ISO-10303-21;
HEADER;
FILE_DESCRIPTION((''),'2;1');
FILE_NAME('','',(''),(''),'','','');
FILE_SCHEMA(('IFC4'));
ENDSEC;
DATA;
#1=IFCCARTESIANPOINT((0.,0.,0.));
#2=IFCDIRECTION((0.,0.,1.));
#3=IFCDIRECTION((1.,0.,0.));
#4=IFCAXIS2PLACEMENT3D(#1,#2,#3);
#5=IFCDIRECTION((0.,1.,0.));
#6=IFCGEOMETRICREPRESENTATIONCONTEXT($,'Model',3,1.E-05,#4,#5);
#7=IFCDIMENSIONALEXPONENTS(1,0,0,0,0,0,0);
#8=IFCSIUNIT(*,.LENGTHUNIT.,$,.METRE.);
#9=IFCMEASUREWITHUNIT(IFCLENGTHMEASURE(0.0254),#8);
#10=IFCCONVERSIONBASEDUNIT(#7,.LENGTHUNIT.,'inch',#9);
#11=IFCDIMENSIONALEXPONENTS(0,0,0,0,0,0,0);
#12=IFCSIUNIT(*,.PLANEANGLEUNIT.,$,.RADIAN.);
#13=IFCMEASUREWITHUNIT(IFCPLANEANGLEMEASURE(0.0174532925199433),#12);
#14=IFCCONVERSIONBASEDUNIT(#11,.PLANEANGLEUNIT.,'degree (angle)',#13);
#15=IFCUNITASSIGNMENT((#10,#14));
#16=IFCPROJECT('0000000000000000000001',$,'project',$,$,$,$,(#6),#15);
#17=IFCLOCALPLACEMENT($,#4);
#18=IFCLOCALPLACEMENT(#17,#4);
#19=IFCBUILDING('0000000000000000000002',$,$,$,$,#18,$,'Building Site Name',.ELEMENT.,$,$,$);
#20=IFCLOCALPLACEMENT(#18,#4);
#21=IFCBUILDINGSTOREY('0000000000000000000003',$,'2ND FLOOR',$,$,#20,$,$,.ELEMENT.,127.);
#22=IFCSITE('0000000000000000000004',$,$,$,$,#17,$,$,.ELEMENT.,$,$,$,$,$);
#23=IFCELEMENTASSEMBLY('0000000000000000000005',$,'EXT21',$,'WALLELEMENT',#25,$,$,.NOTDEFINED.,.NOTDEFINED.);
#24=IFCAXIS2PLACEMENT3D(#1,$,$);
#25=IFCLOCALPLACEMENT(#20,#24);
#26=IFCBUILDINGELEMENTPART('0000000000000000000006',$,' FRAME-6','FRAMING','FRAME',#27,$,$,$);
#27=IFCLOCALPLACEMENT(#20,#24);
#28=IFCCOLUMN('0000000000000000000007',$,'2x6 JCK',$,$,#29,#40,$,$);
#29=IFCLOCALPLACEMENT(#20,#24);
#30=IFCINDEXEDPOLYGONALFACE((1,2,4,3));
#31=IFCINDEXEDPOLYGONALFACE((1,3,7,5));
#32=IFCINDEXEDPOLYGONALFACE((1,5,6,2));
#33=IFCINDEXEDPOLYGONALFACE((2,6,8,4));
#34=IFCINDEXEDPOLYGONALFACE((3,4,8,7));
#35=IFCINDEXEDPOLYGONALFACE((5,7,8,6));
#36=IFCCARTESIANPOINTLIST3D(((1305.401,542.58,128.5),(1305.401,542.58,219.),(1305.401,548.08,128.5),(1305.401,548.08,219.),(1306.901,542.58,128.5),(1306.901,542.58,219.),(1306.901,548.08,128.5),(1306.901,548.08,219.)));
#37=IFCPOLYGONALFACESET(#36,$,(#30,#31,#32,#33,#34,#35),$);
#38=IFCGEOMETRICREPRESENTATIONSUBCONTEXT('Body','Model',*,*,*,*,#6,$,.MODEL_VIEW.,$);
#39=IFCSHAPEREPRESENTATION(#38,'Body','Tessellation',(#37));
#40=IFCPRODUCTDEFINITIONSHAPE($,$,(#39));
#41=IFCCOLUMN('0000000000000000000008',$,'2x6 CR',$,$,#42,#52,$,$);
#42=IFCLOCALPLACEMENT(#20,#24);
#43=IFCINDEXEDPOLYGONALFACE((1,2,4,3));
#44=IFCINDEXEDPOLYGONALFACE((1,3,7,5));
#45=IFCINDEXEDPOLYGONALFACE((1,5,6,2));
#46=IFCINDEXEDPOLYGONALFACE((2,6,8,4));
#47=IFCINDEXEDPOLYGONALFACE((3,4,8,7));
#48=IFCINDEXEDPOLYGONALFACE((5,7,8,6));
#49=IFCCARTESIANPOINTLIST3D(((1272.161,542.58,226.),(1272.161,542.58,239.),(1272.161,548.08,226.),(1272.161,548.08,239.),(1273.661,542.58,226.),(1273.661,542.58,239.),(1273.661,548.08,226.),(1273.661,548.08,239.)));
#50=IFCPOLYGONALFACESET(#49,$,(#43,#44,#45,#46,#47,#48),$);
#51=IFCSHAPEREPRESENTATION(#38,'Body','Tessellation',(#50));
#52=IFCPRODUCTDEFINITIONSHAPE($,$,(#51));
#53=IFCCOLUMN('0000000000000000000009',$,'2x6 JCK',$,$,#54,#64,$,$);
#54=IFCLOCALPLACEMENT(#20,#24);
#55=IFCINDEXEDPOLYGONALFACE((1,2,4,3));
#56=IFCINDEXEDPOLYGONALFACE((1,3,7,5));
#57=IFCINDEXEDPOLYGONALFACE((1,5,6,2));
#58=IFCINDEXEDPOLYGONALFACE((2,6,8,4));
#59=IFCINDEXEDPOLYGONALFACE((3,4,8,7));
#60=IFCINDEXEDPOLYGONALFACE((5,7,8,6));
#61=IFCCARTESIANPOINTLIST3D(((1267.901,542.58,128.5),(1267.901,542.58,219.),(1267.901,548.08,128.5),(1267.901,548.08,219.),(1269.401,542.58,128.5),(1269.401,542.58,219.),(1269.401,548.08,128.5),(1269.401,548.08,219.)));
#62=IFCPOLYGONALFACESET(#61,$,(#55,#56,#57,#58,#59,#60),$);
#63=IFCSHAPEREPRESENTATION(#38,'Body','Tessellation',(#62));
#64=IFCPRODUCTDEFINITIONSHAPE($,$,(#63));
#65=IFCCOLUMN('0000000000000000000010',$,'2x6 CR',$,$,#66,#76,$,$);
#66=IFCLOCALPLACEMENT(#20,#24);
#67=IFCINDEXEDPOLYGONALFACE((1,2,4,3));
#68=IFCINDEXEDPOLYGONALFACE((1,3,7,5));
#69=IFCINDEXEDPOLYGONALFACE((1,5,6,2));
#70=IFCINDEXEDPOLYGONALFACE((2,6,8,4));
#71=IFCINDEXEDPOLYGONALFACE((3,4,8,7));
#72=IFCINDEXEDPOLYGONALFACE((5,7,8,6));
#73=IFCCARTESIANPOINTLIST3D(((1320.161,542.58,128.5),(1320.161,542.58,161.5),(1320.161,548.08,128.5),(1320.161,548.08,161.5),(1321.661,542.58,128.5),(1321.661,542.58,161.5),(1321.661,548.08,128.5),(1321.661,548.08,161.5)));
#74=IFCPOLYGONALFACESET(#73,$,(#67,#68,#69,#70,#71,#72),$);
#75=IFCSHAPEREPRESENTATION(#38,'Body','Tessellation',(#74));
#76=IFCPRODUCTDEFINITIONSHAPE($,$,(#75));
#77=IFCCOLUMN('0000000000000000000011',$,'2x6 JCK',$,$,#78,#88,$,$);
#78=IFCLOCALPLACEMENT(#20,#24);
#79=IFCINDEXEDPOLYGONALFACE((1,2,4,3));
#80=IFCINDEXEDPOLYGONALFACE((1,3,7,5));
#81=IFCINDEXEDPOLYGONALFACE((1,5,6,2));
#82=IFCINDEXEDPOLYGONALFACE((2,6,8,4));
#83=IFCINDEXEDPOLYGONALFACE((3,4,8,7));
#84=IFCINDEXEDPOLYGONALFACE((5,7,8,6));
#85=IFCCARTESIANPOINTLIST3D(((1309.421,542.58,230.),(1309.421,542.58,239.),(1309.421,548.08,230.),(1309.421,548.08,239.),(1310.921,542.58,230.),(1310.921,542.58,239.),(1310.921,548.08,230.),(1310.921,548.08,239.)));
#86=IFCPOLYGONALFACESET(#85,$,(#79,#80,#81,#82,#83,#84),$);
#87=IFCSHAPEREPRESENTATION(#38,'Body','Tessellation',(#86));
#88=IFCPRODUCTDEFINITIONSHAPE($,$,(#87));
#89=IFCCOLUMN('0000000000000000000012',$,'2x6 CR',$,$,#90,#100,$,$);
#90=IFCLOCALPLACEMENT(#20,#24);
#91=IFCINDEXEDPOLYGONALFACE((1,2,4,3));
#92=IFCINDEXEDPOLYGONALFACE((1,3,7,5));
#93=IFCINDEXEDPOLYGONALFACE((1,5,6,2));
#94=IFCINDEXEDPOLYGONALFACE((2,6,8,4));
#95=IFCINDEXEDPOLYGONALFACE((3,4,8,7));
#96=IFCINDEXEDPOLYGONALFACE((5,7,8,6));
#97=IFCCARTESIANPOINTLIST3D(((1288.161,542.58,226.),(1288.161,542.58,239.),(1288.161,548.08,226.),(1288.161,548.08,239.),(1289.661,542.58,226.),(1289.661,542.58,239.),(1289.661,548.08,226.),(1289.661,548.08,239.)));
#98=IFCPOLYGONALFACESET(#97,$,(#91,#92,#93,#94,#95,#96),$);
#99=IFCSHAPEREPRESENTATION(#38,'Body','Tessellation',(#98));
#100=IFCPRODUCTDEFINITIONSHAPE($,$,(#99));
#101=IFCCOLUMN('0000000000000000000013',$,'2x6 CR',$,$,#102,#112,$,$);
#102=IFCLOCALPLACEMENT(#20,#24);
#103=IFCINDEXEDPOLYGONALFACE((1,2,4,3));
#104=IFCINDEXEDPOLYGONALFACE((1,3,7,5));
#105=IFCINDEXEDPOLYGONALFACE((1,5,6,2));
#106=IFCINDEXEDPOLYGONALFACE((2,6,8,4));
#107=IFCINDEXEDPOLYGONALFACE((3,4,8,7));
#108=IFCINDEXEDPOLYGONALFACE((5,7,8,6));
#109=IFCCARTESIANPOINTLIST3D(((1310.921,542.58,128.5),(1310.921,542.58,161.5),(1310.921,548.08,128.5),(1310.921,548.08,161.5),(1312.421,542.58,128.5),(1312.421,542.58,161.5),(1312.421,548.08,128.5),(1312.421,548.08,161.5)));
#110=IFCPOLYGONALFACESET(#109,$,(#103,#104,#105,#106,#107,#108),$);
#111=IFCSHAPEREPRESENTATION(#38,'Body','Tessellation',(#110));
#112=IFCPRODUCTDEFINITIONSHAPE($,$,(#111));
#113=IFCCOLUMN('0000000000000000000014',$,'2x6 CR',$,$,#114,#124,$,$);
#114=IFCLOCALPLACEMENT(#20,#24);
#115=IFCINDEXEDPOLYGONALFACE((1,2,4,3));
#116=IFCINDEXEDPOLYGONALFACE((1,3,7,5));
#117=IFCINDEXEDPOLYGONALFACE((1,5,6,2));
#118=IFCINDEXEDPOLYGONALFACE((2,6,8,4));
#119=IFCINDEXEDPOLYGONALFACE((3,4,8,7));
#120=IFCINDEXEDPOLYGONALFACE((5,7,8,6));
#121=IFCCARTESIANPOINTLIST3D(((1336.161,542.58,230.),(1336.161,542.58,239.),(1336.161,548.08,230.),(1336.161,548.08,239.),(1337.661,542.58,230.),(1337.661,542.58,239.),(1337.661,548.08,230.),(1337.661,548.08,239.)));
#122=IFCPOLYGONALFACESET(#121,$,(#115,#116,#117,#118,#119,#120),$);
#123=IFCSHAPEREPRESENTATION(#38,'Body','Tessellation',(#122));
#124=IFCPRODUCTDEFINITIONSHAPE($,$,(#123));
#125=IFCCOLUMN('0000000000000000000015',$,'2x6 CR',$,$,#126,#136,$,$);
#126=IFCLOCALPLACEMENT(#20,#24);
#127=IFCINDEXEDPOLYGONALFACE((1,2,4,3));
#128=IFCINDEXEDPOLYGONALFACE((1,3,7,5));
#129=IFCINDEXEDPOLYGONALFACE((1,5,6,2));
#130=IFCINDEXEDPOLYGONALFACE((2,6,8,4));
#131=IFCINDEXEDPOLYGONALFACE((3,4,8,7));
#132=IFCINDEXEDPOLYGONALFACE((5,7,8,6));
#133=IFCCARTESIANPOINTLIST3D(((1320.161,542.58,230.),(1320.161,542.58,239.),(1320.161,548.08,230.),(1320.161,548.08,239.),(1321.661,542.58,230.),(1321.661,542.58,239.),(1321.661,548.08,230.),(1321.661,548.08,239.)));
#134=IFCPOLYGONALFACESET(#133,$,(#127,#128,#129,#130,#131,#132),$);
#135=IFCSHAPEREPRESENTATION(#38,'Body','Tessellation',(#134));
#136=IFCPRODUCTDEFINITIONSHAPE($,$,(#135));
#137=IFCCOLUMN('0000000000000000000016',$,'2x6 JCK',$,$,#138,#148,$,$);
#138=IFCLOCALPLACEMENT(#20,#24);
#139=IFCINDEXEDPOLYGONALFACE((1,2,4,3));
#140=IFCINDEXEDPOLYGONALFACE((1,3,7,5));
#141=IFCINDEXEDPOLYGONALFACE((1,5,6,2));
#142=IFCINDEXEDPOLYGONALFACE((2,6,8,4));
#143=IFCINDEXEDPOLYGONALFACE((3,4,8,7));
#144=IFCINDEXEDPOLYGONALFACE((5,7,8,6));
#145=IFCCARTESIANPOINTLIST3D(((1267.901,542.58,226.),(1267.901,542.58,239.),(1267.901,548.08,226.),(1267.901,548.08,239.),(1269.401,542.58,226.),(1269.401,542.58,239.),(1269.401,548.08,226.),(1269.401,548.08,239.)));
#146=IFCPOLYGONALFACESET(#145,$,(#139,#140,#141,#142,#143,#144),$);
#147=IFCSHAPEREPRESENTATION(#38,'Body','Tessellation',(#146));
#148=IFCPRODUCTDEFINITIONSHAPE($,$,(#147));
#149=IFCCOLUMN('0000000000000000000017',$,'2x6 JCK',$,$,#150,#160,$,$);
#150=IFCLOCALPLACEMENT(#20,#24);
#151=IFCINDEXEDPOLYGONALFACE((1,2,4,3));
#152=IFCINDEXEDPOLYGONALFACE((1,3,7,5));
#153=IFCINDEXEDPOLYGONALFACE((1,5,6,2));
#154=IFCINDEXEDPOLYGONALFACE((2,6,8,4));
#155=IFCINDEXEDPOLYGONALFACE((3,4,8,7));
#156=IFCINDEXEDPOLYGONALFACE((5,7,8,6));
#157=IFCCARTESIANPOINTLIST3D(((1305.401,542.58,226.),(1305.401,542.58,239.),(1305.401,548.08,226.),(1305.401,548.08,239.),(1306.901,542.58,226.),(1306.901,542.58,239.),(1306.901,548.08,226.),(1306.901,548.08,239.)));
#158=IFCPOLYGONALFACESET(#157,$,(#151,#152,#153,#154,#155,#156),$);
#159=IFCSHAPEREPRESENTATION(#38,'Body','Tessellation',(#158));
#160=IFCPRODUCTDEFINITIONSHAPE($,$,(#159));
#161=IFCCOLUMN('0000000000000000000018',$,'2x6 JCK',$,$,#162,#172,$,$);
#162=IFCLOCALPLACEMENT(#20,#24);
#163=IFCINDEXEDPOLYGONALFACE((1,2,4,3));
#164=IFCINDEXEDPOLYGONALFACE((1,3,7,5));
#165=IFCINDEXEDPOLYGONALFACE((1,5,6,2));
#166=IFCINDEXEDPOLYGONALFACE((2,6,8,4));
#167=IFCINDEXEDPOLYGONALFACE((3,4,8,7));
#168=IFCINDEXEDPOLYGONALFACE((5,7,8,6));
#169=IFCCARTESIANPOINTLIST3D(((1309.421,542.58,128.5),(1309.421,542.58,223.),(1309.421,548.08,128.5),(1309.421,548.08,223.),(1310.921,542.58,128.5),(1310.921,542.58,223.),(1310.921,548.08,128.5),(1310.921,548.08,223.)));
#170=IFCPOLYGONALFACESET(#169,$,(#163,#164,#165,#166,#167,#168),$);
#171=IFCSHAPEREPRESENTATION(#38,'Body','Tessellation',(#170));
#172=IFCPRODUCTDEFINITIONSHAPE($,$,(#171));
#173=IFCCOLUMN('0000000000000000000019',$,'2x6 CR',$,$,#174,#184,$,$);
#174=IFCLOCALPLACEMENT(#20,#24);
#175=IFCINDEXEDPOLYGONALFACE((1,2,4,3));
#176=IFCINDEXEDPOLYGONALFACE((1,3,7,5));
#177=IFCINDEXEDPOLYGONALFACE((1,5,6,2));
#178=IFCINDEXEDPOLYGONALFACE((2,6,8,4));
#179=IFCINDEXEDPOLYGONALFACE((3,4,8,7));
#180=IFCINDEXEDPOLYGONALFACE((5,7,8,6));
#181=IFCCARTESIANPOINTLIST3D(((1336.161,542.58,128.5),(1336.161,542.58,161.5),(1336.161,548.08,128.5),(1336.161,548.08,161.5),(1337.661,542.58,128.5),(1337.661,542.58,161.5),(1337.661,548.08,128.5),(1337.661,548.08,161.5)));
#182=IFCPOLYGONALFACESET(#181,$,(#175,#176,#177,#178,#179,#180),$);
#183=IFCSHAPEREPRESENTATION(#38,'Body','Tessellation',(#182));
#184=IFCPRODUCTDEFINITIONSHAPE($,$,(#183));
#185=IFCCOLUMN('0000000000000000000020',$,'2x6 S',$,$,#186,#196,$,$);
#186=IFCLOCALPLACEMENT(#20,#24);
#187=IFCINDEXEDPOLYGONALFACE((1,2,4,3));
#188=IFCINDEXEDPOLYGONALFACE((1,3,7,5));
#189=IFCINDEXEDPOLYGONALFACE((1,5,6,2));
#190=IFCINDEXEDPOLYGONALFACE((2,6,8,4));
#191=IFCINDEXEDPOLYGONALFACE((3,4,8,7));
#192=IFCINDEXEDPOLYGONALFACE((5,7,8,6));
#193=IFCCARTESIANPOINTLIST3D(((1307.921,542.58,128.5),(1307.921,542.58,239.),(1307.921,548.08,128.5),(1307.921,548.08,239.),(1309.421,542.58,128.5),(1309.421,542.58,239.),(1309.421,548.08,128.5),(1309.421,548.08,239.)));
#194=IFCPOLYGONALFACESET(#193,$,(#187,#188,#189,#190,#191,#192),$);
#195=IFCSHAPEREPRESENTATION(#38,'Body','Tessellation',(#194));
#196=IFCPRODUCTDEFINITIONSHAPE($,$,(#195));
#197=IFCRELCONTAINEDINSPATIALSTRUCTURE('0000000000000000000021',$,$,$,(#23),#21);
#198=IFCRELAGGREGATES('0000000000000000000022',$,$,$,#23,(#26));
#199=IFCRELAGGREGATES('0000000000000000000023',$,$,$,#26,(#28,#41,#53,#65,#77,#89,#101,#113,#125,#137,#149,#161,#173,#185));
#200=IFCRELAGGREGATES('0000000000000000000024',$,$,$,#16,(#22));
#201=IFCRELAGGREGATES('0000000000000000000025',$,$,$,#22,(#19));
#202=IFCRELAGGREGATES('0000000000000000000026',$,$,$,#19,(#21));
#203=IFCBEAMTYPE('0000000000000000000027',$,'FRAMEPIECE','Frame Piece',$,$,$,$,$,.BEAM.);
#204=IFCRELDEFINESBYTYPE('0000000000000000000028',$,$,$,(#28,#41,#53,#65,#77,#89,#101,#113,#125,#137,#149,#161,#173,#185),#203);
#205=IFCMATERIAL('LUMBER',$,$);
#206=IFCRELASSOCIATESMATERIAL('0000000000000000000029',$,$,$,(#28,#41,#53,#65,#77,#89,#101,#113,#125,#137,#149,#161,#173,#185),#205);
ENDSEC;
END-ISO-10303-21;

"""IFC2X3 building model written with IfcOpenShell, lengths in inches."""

from ifc_helpers import new_model, entity, si_unit, converted_unit, direction, frame, frame_2d, origin_with_axes, place, context, subcontext, project, spatial, rectangle, extrude, material, type_object, element, aggregate, save


model = new_model("IFC2X3")

# Units and contexts
model_context = context("Model", 3, precision=1e-05, world=origin_with_axes(), true_north=direction((0.0, 1.0, 0.0)))
body_context = subcontext(model_context, "Body", "Model", "MODEL_VIEW")
ifc_project = project(units=[converted_unit("LENGTHUNIT", "inch", entity("IfcLengthMeasure", 0.0254), si_unit("LENGTHUNIT", "METRE"), dimensions=[1, 0, 0, 0, 0, 0, 0]), converted_unit("PLANEANGLEUNIT", "degree (angle)", entity("IfcPlaneAngleMeasure", 0.0174532925199433), si_unit("PLANEANGLEUNIT", "RADIAN"), dimensions=[0, 0, 0, 0, 0, 0, 0])], contexts=[model_context])

# Site, building, storey
site_placement = place(None, origin_with_axes())
site = spatial("IfcSite", under=ifc_project, at=site_placement, CompositionType="ELEMENT")
building_placement = place(site_placement, origin_with_axes())
building = spatial("IfcBuilding", under=site, at=building_placement, LongName="Building Site Name", CompositionType="ELEMENT")
storey_placement = place(building_placement, origin_with_axes())
storey = spatial("IfcBuildingStorey", under=building, at=storey_placement, Name="2ND FLOOR", CompositionType="ELEMENT", Elevation=127.0)

# Element assembly, building element part, columns
assembly_1_placement = place(storey_placement, origin_with_axes())
assembly_1 = element("IfcElementAssembly", 1, at=assembly_1_placement, inside=storey, Name="EXT21", ObjectType="WALLELEMENT", AssemblyPlace="NOTDEFINED", PredefinedType="NOTDEFINED")
building_element_part_1 = element("IfcBuildingElementPart", 2, Name=" FRAME-6", Description="FRAMING", ObjectType="FRAME")
aggregate(assembly_1, [building_element_part_1])
ifc_material_1 = material(Name="LUMBER")
beam_type = type_object("IfcBeamType", Name="FRAMEPIECE", Description="Frame Piece", PredefinedType="BEAM")
column_1_placement = place(assembly_1_placement, frame((1306.151, 545.33, 128.5), z_axis=(0.0, 0.0, 1.0), x_axis=(-1.0, 0.0, 0.0)))
column_1 = element("IfcColumn", 3, at=column_1_placement, type_object=beam_type, material=ifc_material_1, Name="2x6 JCK", context=body_context, shape_type="SweptSolid", body=[
    extrude(rectangle(XDim=1.5, YDim=5.5, at=frame_2d((0.0, 0.0), x_axis=(-1.0, 0.0))), origin_with_axes(), (0.0, 0.0, 1.0), 90.5),
])
column_2_placement = place(assembly_1_placement, frame((1272.911, 545.33, 239.0), z_axis=(0.0, 0.0, -1.0), x_axis=(1.0, 0.0, 0.0)))
column_2 = element("IfcColumn", 4, at=column_2_placement, type_object=beam_type, material=ifc_material_1, Name="2x6 CR", context=body_context, shape_type="SweptSolid", body=[
    extrude(rectangle(XDim=1.5, YDim=5.5, at=frame_2d((0.0, 0.0), x_axis=(-1.0, 0.0))), origin_with_axes(), (0.0, 0.0, 1.0), 13.0),
])
column_3_placement = place(assembly_1_placement, frame((1268.651, 545.33, 219.0), z_axis=(0.0, 0.0, -1.0), x_axis=(1.0, 0.0, 0.0)))
column_3 = element("IfcColumn", 5, at=column_3_placement, type_object=beam_type, material=ifc_material_1, Name="2x6 JCK", context=body_context, shape_type="SweptSolid", body=[
    extrude(rectangle(XDim=1.5, YDim=5.5, at=frame_2d((0.0, 0.0), x_axis=(-1.0, 0.0))), origin_with_axes(), (0.0, 0.0, 1.0), 90.5),
])
column_4_placement = place(assembly_1_placement, frame((1320.911, 545.33, 161.5), z_axis=(0.0, 0.0, -1.0), x_axis=(1.0, 0.0, 0.0)))
column_4 = element("IfcColumn", 6, at=column_4_placement, type_object=beam_type, material=ifc_material_1, Name="2x6 CR", context=body_context, shape_type="SweptSolid", body=[
    extrude(rectangle(XDim=1.5, YDim=5.5, at=frame_2d((0.0, 0.0), x_axis=(-1.0, 0.0))), origin_with_axes(), (0.0, 0.0, 1.0), 33.0),
])
column_5_placement = place(assembly_1_placement, frame((1310.171, 545.33, 239.0), z_axis=(0.0, 0.0, -1.0), x_axis=(1.0, 0.0, 0.0)))
column_5 = element("IfcColumn", 7, at=column_5_placement, type_object=beam_type, material=ifc_material_1, Name="2x6 JCK", context=body_context, shape_type="SweptSolid", body=[
    extrude(rectangle(XDim=1.5, YDim=5.5, at=frame_2d((0.0, 0.0), x_axis=(-1.0, 0.0))), origin_with_axes(), (0.0, 0.0, 1.0), 9.0),
])
column_6_placement = place(assembly_1_placement, frame((1288.911, 545.33, 239.0), z_axis=(0.0, 0.0, -1.0), x_axis=(1.0, 0.0, 0.0)))
column_6 = element("IfcColumn", 8, at=column_6_placement, type_object=beam_type, material=ifc_material_1, Name="2x6 CR", context=body_context, shape_type="SweptSolid", body=[
    extrude(rectangle(XDim=1.5, YDim=5.5, at=frame_2d((0.0, 0.0), x_axis=(-1.0, 0.0))), origin_with_axes(), (0.0, 0.0, 1.0), 13.0),
])
column_7_placement = place(assembly_1_placement, frame((1311.671, 545.33, 161.5), z_axis=(0.0, 0.0, -1.0), x_axis=(1.0, 0.0, 0.0)))
column_7 = element("IfcColumn", 9, at=column_7_placement, type_object=beam_type, material=ifc_material_1, Name="2x6 CR", context=body_context, shape_type="SweptSolid", body=[
    extrude(rectangle(XDim=1.5, YDim=5.5, at=frame_2d((0.0, 0.0), x_axis=(-1.0, 0.0))), origin_with_axes(), (0.0, 0.0, 1.0), 33.0),
])
column_8_placement = place(assembly_1_placement, frame((1336.911, 545.33, 239.0), z_axis=(0.0, 0.0, -1.0), x_axis=(1.0, 0.0, 0.0)))
column_8 = element("IfcColumn", 10, at=column_8_placement, type_object=beam_type, material=ifc_material_1, Name="2x6 CR", context=body_context, shape_type="SweptSolid", body=[
    extrude(rectangle(XDim=1.5, YDim=5.5, at=frame_2d((0.0, 0.0), x_axis=(-1.0, 0.0))), origin_with_axes(), (0.0, 0.0, 1.0), 9.0),
])
column_9_placement = place(assembly_1_placement, frame((1320.911, 545.33, 239.0), z_axis=(0.0, 0.0, -1.0), x_axis=(1.0, 0.0, 0.0)))
column_9 = element("IfcColumn", 11, at=column_9_placement, type_object=beam_type, material=ifc_material_1, Name="2x6 CR", context=body_context, shape_type="SweptSolid", body=[
    extrude(rectangle(XDim=1.5, YDim=5.5, at=frame_2d((0.0, 0.0), x_axis=(-1.0, 0.0))), origin_with_axes(), (0.0, 0.0, 1.0), 9.0),
])
column_10_placement = place(assembly_1_placement, frame((1268.651, 545.33, 239.0), z_axis=(0.0, 0.0, -1.0), x_axis=(1.0, 0.0, 0.0)))
column_10 = element("IfcColumn", 12, at=column_10_placement, type_object=beam_type, material=ifc_material_1, Name="2x6 JCK", context=body_context, shape_type="SweptSolid", body=[
    extrude(rectangle(XDim=1.5, YDim=5.5, at=frame_2d((0.0, 0.0), x_axis=(-1.0, 0.0))), origin_with_axes(), (0.0, 0.0, 1.0), 13.0),
])
column_11_placement = place(assembly_1_placement, frame((1306.151, 545.33, 226.0), z_axis=(0.0, 0.0, 1.0), x_axis=(-1.0, 0.0, 0.0)))
column_11 = element("IfcColumn", 13, at=column_11_placement, type_object=beam_type, material=ifc_material_1, Name="2x6 JCK", context=body_context, shape_type="SweptSolid", body=[
    extrude(rectangle(XDim=1.5, YDim=5.5, at=frame_2d((0.0, 0.0), x_axis=(-1.0, 0.0))), origin_with_axes(), (0.0, 0.0, 1.0), 13.0),
])
column_12_placement = place(assembly_1_placement, frame((1310.171, 545.33, 223.0), z_axis=(0.0, 0.0, -1.0), x_axis=(1.0, 0.0, 0.0)))
column_12 = element("IfcColumn", 14, at=column_12_placement, type_object=beam_type, material=ifc_material_1, Name="2x6 JCK", context=body_context, shape_type="SweptSolid", body=[
    extrude(rectangle(XDim=1.5, YDim=5.5, at=frame_2d((0.0, 0.0), x_axis=(-1.0, 0.0))), origin_with_axes(), (0.0, 0.0, 1.0), 94.5),
])
column_13_placement = place(assembly_1_placement, frame((1336.911, 545.33, 161.5), z_axis=(0.0, 0.0, -1.0), x_axis=(1.0, 0.0, 0.0)))
column_13 = element("IfcColumn", 15, at=column_13_placement, type_object=beam_type, material=ifc_material_1, Name="2x6 CR", context=body_context, shape_type="SweptSolid", body=[
    extrude(rectangle(XDim=1.5, YDim=5.5, at=frame_2d((0.0, 0.0), x_axis=(-1.0, 0.0))), origin_with_axes(), (0.0, 0.0, 1.0), 33.0),
])
column_14_placement = place(assembly_1_placement, frame((1308.671, 545.33, 239.0), z_axis=(0.0, 0.0, -1.0), x_axis=(1.0, 0.0, 0.0)))
column_14 = element("IfcColumn", 16, at=column_14_placement, type_object=beam_type, material=ifc_material_1, Name="2x6 S", context=body_context, shape_type="SweptSolid", body=[
    extrude(rectangle(XDim=1.5, YDim=5.5, at=frame_2d((0.0, 0.0), x_axis=(-1.0, 0.0))), origin_with_axes(), (0.0, 0.0, 1.0), 110.5),
])

aggregate(building_element_part_1, [column_1, column_2, column_3, column_4, column_5, column_6, column_7, column_8, column_9, column_10, column_11, column_12, column_13, column_14])

save(model, "model.ifc")
